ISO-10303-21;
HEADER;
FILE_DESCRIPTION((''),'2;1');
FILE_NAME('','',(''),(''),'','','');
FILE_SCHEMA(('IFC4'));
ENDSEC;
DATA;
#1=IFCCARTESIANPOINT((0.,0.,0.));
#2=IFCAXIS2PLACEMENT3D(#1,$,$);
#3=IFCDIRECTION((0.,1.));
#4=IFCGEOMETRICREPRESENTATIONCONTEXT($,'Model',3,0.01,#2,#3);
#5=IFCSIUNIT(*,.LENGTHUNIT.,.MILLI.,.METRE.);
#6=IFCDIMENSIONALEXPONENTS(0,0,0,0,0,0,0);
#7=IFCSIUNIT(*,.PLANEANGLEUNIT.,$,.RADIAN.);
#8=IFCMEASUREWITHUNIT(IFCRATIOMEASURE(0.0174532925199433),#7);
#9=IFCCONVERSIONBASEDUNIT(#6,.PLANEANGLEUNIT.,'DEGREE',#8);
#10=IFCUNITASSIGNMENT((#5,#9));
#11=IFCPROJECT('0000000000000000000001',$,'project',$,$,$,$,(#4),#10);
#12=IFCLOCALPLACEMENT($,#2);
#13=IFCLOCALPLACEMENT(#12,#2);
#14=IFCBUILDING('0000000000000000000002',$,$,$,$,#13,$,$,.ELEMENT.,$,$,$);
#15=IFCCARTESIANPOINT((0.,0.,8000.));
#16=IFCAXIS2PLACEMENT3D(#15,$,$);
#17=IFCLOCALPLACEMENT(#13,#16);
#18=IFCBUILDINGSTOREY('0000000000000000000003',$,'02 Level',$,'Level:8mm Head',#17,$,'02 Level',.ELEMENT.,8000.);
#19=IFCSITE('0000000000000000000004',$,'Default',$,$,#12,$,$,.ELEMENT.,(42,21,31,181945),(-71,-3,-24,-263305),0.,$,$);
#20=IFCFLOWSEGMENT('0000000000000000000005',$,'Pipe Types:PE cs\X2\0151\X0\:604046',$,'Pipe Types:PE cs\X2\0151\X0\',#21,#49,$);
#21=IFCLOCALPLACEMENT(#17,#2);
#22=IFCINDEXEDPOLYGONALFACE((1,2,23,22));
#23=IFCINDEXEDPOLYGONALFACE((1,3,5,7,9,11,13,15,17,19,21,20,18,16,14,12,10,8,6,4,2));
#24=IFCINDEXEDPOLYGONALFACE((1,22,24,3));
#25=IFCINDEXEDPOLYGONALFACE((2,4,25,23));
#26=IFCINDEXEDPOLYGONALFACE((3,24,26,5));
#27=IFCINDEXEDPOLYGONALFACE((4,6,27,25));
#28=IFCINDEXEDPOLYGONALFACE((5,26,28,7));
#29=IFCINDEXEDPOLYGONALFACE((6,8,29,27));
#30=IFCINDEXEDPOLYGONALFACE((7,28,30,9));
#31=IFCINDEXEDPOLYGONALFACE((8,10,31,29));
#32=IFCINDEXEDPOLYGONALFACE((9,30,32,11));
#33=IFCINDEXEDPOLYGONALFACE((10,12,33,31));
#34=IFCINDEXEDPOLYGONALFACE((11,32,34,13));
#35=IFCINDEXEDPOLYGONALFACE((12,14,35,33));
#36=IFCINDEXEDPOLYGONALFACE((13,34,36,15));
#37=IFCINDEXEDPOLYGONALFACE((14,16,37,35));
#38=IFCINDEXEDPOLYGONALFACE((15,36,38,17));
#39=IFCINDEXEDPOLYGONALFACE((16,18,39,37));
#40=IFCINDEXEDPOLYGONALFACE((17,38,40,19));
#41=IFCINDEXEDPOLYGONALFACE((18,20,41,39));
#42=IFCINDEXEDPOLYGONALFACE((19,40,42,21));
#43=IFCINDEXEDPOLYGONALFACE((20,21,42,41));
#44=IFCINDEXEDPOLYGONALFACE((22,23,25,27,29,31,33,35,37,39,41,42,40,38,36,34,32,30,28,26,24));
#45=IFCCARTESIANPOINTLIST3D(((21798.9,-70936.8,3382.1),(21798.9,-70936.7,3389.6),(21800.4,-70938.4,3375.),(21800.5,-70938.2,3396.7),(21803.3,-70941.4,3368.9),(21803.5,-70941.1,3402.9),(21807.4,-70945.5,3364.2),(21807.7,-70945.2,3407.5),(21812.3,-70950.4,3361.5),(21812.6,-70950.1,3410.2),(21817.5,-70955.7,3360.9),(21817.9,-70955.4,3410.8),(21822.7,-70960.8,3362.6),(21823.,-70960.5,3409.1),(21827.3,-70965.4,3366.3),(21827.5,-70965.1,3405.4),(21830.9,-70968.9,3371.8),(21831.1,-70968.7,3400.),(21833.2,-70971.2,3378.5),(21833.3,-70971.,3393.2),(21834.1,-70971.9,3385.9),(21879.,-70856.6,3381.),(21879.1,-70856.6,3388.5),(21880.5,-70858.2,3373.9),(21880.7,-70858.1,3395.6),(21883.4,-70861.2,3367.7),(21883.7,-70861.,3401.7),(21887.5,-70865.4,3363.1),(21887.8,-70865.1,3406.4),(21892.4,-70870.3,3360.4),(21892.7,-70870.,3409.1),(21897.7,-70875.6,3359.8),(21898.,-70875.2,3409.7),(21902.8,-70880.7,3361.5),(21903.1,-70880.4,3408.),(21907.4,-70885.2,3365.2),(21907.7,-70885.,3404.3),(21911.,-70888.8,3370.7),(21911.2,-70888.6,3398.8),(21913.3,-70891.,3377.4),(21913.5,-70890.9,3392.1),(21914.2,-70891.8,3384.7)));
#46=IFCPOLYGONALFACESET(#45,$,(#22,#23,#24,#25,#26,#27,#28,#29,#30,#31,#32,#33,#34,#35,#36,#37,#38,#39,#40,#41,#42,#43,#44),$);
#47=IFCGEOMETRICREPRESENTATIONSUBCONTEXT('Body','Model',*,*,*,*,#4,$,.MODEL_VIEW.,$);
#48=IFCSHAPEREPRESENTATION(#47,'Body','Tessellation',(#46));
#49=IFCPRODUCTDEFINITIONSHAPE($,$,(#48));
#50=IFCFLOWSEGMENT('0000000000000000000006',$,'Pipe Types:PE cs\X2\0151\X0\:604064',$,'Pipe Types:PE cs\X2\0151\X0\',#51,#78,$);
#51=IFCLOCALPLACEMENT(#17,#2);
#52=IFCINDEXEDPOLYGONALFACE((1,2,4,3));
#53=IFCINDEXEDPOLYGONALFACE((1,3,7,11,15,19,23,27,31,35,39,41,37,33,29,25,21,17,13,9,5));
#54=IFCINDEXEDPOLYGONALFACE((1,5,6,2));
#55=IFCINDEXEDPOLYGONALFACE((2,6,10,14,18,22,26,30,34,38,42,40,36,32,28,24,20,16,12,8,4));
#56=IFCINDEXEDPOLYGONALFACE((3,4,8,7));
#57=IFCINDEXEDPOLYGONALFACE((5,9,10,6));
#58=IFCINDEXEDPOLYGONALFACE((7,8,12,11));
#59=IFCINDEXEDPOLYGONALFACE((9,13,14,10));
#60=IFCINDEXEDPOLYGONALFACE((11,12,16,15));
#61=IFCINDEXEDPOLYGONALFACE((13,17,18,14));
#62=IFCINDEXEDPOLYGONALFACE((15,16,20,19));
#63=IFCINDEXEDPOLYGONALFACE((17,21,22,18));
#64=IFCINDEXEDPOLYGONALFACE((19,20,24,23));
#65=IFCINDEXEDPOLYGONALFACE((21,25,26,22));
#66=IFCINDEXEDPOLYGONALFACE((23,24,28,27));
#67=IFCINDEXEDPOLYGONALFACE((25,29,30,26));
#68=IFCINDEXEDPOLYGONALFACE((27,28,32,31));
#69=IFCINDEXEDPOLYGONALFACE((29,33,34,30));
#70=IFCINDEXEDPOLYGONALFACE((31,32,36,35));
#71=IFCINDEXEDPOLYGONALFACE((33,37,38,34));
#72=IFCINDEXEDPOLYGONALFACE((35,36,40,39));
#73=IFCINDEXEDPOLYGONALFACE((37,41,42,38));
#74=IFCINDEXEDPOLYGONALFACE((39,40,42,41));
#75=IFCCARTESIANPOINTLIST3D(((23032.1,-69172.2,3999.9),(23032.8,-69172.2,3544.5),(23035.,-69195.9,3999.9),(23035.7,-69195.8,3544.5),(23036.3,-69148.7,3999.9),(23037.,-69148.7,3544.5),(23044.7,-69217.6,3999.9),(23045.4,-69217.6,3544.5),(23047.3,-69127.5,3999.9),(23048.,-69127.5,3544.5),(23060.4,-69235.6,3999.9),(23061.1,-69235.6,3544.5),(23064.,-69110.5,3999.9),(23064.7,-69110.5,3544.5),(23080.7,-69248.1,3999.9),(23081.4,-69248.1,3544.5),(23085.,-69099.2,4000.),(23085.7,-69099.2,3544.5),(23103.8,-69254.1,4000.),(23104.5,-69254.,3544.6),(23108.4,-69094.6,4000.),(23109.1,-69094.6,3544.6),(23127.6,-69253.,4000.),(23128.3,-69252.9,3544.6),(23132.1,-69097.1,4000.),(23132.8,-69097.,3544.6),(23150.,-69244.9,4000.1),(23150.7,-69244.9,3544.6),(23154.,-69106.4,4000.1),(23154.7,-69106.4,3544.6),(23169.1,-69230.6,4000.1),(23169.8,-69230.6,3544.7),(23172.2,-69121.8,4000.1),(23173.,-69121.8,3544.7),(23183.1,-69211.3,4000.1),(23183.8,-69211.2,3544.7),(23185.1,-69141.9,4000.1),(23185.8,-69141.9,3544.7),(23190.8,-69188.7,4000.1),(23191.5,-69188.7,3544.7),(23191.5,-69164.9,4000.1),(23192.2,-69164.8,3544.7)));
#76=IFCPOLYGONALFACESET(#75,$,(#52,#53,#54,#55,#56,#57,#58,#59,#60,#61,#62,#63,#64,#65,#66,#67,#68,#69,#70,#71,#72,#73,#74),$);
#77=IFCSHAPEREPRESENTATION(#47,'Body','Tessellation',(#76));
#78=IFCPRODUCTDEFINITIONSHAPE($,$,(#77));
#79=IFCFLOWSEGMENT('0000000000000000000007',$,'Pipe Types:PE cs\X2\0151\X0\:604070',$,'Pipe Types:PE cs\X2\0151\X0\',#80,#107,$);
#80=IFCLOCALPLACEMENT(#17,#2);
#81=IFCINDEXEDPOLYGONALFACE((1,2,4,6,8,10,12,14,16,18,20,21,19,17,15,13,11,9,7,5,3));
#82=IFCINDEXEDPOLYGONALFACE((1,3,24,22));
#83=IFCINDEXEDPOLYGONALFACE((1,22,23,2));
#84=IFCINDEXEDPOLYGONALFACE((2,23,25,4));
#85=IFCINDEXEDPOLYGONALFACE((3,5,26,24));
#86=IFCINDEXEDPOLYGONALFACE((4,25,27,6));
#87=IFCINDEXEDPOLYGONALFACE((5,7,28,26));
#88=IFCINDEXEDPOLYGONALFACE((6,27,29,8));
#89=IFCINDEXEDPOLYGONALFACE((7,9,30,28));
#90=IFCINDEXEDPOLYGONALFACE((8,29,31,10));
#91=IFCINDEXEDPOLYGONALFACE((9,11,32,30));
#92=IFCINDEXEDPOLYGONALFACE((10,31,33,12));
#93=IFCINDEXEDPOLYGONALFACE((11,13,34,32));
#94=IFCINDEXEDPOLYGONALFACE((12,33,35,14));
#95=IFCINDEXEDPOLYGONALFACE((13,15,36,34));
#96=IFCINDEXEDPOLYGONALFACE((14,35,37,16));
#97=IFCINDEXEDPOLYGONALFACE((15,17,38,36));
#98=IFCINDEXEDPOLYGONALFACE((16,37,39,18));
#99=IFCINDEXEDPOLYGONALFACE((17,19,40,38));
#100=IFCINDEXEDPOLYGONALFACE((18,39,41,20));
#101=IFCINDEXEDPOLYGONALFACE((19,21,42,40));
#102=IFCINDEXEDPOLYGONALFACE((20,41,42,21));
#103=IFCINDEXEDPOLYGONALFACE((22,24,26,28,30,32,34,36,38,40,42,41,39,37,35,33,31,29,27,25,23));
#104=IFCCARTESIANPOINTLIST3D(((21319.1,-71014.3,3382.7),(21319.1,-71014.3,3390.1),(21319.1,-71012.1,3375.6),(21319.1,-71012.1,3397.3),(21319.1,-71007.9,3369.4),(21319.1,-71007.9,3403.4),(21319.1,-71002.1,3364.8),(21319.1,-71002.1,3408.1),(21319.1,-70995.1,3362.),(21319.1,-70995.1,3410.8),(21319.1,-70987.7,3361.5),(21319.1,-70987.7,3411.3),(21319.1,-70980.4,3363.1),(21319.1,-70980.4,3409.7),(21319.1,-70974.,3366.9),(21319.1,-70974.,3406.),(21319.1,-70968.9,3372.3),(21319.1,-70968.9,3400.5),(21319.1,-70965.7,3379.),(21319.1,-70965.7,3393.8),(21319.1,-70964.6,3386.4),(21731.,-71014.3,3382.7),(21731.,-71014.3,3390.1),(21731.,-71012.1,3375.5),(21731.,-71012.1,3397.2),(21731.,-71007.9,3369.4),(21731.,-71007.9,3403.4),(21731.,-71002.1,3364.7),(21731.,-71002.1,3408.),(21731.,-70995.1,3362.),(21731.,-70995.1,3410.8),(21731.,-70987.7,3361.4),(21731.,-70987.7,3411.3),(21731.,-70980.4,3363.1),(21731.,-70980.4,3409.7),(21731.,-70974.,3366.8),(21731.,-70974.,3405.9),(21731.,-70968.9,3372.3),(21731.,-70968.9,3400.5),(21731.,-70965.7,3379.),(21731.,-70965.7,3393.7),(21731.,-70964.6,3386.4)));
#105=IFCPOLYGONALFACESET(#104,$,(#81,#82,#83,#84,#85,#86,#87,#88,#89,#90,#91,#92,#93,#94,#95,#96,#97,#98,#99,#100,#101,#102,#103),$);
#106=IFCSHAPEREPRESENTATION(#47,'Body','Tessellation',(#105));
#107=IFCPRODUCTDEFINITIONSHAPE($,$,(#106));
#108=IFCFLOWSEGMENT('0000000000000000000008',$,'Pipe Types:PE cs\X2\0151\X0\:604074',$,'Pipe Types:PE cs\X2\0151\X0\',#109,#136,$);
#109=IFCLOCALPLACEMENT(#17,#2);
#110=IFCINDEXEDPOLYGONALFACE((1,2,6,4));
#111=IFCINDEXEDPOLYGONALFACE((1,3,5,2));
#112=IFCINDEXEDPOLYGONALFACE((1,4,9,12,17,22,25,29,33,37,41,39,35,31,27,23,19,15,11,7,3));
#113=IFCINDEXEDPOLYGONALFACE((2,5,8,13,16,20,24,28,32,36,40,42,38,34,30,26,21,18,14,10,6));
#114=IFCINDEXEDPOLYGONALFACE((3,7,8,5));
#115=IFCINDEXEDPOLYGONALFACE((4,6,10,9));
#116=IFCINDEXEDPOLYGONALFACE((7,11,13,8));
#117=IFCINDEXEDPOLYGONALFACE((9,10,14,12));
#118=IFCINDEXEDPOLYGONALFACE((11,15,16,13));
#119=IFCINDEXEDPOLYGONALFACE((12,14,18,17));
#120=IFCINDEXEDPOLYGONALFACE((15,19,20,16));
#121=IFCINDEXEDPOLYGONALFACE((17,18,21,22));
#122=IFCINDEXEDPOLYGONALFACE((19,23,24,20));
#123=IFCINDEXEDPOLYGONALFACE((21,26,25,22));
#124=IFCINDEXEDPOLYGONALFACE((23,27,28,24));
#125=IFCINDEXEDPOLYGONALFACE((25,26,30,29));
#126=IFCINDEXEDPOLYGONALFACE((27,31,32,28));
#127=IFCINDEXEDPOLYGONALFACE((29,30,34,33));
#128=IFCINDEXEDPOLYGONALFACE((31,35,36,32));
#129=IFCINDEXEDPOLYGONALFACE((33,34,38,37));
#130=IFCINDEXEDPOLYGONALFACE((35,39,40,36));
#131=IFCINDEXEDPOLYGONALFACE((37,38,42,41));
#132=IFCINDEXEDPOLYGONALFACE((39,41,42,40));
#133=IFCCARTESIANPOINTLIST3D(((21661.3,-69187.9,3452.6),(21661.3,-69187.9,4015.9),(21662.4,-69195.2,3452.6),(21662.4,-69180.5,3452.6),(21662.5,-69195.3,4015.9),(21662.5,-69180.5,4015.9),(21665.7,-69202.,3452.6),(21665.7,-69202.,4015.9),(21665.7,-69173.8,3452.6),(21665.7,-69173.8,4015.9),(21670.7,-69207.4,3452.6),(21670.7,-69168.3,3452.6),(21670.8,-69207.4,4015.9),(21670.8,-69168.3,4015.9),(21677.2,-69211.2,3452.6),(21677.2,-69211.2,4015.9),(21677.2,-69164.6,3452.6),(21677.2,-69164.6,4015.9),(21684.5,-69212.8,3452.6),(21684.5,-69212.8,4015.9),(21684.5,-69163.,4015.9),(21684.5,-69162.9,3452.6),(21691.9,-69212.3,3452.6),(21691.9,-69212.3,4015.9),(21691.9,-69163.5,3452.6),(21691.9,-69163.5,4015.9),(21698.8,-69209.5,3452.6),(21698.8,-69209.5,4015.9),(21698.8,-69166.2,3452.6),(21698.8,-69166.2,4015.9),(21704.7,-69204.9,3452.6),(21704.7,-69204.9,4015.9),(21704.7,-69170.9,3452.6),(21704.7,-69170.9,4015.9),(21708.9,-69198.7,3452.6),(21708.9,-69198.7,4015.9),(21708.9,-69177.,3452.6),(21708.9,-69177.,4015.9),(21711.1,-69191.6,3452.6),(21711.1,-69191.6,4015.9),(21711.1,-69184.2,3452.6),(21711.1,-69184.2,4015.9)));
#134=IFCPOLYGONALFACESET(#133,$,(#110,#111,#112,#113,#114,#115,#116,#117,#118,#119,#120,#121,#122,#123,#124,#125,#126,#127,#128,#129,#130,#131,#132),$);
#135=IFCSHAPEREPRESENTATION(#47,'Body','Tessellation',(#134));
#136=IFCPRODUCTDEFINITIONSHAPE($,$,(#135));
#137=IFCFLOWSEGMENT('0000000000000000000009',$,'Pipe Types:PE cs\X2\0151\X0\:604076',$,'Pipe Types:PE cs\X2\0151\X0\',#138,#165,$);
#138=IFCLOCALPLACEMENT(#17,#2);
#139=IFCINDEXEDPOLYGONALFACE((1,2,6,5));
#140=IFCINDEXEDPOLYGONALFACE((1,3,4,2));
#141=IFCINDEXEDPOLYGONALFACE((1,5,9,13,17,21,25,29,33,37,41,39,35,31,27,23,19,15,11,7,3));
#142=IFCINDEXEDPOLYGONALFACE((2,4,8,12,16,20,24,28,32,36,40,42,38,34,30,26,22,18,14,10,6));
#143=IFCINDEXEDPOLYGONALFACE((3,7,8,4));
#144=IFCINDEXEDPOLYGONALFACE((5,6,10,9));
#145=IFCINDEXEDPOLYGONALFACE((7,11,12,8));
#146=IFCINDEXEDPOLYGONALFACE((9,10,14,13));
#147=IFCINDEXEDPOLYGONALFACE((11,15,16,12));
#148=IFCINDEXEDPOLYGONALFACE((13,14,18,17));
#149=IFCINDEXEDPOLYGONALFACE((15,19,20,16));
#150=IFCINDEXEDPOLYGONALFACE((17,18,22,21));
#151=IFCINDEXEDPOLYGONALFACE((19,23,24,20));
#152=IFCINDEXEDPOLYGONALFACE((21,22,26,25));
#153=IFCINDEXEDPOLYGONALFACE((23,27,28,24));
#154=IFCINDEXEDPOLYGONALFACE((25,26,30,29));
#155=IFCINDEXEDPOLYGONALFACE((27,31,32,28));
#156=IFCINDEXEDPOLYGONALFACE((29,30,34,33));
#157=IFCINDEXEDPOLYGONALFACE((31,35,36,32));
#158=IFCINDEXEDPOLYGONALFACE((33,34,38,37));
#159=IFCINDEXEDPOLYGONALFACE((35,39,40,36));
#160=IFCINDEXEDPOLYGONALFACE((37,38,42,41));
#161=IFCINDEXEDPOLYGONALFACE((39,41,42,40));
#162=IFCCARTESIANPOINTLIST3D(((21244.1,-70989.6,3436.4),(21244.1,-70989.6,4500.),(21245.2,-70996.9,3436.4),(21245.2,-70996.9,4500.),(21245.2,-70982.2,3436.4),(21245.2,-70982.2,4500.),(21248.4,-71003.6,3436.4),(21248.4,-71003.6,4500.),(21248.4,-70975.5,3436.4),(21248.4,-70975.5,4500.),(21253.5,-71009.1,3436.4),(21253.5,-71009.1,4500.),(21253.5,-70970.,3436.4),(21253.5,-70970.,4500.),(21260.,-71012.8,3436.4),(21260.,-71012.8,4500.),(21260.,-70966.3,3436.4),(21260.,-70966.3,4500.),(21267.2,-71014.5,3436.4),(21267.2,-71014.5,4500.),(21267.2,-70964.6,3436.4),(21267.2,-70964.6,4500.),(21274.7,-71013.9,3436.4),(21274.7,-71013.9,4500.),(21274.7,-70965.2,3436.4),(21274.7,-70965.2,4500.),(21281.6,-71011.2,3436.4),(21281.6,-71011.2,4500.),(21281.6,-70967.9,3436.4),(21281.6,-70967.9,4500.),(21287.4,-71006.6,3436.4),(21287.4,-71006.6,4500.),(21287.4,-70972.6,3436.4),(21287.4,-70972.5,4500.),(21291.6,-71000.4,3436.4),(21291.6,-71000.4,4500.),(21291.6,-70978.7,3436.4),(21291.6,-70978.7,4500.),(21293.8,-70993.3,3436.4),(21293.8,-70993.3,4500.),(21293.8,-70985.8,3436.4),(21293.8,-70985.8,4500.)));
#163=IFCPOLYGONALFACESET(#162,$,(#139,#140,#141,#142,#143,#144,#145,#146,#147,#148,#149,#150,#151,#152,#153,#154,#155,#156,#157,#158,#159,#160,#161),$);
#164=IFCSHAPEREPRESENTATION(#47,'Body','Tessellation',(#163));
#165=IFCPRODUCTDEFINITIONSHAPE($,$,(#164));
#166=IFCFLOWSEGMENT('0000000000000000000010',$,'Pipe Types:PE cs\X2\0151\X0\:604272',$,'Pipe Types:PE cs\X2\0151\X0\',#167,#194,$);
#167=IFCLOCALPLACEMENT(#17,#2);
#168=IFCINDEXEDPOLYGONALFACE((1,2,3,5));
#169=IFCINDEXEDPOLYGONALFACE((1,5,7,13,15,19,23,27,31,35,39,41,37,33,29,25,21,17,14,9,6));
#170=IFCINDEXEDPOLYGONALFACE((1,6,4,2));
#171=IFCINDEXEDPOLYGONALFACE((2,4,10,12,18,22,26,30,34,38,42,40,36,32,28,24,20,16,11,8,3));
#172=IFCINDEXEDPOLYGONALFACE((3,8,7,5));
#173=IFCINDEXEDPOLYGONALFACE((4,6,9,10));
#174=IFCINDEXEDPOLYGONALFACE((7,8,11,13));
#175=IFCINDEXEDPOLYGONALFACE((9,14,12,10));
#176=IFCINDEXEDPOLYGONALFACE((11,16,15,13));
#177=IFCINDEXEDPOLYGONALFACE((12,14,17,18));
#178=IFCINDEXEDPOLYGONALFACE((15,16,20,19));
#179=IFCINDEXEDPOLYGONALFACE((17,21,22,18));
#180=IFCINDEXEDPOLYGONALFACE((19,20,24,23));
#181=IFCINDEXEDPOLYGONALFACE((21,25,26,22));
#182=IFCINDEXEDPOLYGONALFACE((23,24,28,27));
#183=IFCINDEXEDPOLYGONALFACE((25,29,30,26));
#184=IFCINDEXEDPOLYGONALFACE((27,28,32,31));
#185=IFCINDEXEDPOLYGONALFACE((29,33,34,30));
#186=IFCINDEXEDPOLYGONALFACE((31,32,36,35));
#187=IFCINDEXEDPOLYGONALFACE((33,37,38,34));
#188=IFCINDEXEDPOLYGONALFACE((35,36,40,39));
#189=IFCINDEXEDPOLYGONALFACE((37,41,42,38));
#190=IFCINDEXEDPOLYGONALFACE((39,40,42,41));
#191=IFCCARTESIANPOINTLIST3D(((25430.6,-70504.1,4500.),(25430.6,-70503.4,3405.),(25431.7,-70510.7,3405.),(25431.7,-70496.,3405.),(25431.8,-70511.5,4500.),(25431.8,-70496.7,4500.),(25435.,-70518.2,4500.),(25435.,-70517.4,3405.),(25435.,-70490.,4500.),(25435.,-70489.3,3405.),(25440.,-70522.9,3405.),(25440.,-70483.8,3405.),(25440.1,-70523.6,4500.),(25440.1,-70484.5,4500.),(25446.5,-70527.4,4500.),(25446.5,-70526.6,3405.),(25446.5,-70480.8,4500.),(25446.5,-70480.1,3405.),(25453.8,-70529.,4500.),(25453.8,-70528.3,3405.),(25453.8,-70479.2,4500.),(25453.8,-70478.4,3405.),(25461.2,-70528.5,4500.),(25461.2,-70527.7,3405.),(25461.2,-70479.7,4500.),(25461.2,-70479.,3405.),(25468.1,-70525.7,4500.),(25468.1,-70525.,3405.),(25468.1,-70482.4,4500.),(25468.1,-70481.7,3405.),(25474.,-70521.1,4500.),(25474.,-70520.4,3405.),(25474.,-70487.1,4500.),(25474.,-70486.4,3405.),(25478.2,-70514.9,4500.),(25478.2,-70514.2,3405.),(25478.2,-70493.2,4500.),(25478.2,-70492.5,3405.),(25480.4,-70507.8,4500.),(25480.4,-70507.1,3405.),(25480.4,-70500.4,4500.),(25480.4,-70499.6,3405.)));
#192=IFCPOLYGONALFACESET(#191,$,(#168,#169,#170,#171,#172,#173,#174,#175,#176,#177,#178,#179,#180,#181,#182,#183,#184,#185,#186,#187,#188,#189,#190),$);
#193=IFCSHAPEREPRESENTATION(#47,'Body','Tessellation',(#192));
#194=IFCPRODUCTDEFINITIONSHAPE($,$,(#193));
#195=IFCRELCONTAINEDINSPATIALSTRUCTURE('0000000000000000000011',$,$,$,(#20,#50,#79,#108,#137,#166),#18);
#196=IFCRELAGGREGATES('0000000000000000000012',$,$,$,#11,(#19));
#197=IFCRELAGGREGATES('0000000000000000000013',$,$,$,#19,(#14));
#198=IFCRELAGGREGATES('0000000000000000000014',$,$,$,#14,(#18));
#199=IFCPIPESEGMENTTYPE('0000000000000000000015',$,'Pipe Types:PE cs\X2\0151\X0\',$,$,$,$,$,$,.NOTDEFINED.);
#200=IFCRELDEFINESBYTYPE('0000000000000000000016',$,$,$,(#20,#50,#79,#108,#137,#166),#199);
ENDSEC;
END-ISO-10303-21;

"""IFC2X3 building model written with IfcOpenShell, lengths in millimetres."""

from ifc_helpers import new_model, entity, si_unit, converted_unit, direction, frame, frame_2d, origin, origin_2d_with_axis, place, context, subcontext, project, spatial, circle, extrude, type_object, element, save


model = new_model("IFC2X3")

# Units and contexts
model_context = context("Model", 3, precision=0.01, world=origin(), true_north=direction((0.0, 1.0)))
body_context = subcontext(model_context, "Body", "Model", "MODEL_VIEW")
ifc_project = project(units=[si_unit("LENGTHUNIT", "METRE", prefix="MILLI"), converted_unit("PLANEANGLEUNIT", "DEGREE", entity("IfcRatioMeasure", 0.0174532925199433), si_unit("PLANEANGLEUNIT", "RADIAN"), dimensions=[0, 0, 0, 0, 0, 0, 0])], contexts=[model_context])

# Site, building, storey
site_placement = place(None, origin())
site = spatial("IfcSite", under=ifc_project, at=site_placement, Name="Default", CompositionType="ELEMENT", RefLatitude=(42, 21, 31, 181945), RefLongitude=(-71, -3, -24, -263305), RefElevation=0.0)
building_placement = place(site_placement, origin())
building = spatial("IfcBuilding", under=site, at=building_placement, CompositionType="ELEMENT")
storey_placement = place(building_placement, frame((0.0, 0.0, 8000.0)))
storey = spatial("IfcBuildingStorey", under=building, at=storey_placement, Name="02 Level", ObjectType="Level:8mm Head", LongName="02 Level", CompositionType="ELEMENT", Elevation=8000.0)

# Flow segments
pipe_segment_type = type_object("IfcPipeSegmentType", Name="Pipe Types:PE cső", PredefinedType="NOTDEFINED")
flow_segment_1_placement = place(storey_placement, frame((21797.1, -70973.5, 3358.1)))
element("IfcFlowSegment", 1, at=flow_segment_1_placement, inside=storey, type_object=pipe_segment_type, Name="Pipe Types:PE cső:604046", ObjectType="Pipe Types:PE cső", context=body_context, shape_type="SweptSolid", body=[
    extrude(circle(Radius=25.0, at=origin_2d_with_axis()), frame((99.4, 99.4, 26.6), z_axis=(-0.707071, -0.707071, 0.01), x_axis=(0.707107, -0.707107, 0.0)), (0.0, 0.0, 1.0), 113.3),
])
flow_segment_2_placement = place(storey_placement, frame((23030.5, -69256.0, 3544.5)))
element("IfcFlowSegment", 2, at=flow_segment_2_placement, inside=storey, type_object=pipe_segment_type, Name="Pipe Types:PE cső:604064", ObjectType="Pipe Types:PE cső", context=body_context, shape_type="SweptSolid", body=[
    extrude(circle(Radius=80.0, at=origin_2d_with_axis()), frame((82.2, 81.5, 0.1), z_axis=(-0.001564, -0.000072, 0.999999), x_axis=(-0.045923, 0.998945, 0.0)), (0.0, 0.0, 1.0), 455.4),
])
flow_segment_3_placement = place(storey_placement, frame((21319.1, -71016.2, 3359.8)))
element("IfcFlowSegment", 3, at=flow_segment_3_placement, inside=storey, type_object=pipe_segment_type, Name="Pipe Types:PE cső:604070", ObjectType="Pipe Types:PE cső", context=body_context, shape_type="SweptSolid", body=[
    extrude(circle(Radius=25.0, at=origin_2d_with_axis()), frame((0.0, 26.6, 26.6), z_axis=(1.0, 0.0, -0.000085), x_axis=(0.0, 1.0, 0.0)), (0.0, 0.0, 1.0), 411.9),
])
flow_segment_4_placement = place(storey_placement, frame((21659.7, -69214.5, 3452.6)))
element("IfcFlowSegment", 4, at=flow_segment_4_placement, inside=storey, type_object=pipe_segment_type, Name="Pipe Types:PE cső:604074", ObjectType="Pipe Types:PE cső", context=body_context, shape_type="SweptSolid", body=[
    extrude(circle(Radius=25.0, at=frame_2d((0.0, 0.0), x_axis=(1.0, 0.0))), frame((26.6, 26.6, 0.0), z_axis=(0.000019, -0.000019, 1.0), x_axis=(-1.0, 0.0, 0.000019)), (0.0, 0.0, 1.0), 563.3),
])
flow_segment_5_placement = place(storey_placement, frame((21242.5, -71016.2, 3436.4)))
element("IfcFlowSegment", 5, at=flow_segment_5_placement, inside=storey, type_object=pipe_segment_type, Name="Pipe Types:PE cső:604076", ObjectType="Pipe Types:PE cső", context=body_context, shape_type="SweptSolid", body=[
    extrude(circle(Radius=25.0, at=frame_2d((0.0, 0.0), x_axis=(1.0, 0.0))), frame((26.6, 26.6, 0.0), z_axis=(0.0, 0.000009, 1.0), x_axis=(-1.0, 0.0, 0.0)), (0.0, 0.0, 1.0), 1063.6),
])
flow_segment_6_placement = place(storey_placement, frame((25429.0, -70530.7, 3405.0)))
element("IfcFlowSegment", 6, at=flow_segment_6_placement, inside=storey, type_object=pipe_segment_type, Name="Pipe Types:PE cső:604272", ObjectType="Pipe Types:PE cső", context=body_context, shape_type="SweptSolid", body=[
    extrude(circle(Radius=25.0, at=frame_2d((0.0, 0.0), x_axis=(1.0, 0.0))), frame((26.6, 27.3, 0.0), z_axis=(0.000007, -0.000666, 1.0), x_axis=(-1.0, 0.0, 0.000007)), (0.0, 0.0, 1.0), 1095.0),
])

save(model, "model.ifc")
